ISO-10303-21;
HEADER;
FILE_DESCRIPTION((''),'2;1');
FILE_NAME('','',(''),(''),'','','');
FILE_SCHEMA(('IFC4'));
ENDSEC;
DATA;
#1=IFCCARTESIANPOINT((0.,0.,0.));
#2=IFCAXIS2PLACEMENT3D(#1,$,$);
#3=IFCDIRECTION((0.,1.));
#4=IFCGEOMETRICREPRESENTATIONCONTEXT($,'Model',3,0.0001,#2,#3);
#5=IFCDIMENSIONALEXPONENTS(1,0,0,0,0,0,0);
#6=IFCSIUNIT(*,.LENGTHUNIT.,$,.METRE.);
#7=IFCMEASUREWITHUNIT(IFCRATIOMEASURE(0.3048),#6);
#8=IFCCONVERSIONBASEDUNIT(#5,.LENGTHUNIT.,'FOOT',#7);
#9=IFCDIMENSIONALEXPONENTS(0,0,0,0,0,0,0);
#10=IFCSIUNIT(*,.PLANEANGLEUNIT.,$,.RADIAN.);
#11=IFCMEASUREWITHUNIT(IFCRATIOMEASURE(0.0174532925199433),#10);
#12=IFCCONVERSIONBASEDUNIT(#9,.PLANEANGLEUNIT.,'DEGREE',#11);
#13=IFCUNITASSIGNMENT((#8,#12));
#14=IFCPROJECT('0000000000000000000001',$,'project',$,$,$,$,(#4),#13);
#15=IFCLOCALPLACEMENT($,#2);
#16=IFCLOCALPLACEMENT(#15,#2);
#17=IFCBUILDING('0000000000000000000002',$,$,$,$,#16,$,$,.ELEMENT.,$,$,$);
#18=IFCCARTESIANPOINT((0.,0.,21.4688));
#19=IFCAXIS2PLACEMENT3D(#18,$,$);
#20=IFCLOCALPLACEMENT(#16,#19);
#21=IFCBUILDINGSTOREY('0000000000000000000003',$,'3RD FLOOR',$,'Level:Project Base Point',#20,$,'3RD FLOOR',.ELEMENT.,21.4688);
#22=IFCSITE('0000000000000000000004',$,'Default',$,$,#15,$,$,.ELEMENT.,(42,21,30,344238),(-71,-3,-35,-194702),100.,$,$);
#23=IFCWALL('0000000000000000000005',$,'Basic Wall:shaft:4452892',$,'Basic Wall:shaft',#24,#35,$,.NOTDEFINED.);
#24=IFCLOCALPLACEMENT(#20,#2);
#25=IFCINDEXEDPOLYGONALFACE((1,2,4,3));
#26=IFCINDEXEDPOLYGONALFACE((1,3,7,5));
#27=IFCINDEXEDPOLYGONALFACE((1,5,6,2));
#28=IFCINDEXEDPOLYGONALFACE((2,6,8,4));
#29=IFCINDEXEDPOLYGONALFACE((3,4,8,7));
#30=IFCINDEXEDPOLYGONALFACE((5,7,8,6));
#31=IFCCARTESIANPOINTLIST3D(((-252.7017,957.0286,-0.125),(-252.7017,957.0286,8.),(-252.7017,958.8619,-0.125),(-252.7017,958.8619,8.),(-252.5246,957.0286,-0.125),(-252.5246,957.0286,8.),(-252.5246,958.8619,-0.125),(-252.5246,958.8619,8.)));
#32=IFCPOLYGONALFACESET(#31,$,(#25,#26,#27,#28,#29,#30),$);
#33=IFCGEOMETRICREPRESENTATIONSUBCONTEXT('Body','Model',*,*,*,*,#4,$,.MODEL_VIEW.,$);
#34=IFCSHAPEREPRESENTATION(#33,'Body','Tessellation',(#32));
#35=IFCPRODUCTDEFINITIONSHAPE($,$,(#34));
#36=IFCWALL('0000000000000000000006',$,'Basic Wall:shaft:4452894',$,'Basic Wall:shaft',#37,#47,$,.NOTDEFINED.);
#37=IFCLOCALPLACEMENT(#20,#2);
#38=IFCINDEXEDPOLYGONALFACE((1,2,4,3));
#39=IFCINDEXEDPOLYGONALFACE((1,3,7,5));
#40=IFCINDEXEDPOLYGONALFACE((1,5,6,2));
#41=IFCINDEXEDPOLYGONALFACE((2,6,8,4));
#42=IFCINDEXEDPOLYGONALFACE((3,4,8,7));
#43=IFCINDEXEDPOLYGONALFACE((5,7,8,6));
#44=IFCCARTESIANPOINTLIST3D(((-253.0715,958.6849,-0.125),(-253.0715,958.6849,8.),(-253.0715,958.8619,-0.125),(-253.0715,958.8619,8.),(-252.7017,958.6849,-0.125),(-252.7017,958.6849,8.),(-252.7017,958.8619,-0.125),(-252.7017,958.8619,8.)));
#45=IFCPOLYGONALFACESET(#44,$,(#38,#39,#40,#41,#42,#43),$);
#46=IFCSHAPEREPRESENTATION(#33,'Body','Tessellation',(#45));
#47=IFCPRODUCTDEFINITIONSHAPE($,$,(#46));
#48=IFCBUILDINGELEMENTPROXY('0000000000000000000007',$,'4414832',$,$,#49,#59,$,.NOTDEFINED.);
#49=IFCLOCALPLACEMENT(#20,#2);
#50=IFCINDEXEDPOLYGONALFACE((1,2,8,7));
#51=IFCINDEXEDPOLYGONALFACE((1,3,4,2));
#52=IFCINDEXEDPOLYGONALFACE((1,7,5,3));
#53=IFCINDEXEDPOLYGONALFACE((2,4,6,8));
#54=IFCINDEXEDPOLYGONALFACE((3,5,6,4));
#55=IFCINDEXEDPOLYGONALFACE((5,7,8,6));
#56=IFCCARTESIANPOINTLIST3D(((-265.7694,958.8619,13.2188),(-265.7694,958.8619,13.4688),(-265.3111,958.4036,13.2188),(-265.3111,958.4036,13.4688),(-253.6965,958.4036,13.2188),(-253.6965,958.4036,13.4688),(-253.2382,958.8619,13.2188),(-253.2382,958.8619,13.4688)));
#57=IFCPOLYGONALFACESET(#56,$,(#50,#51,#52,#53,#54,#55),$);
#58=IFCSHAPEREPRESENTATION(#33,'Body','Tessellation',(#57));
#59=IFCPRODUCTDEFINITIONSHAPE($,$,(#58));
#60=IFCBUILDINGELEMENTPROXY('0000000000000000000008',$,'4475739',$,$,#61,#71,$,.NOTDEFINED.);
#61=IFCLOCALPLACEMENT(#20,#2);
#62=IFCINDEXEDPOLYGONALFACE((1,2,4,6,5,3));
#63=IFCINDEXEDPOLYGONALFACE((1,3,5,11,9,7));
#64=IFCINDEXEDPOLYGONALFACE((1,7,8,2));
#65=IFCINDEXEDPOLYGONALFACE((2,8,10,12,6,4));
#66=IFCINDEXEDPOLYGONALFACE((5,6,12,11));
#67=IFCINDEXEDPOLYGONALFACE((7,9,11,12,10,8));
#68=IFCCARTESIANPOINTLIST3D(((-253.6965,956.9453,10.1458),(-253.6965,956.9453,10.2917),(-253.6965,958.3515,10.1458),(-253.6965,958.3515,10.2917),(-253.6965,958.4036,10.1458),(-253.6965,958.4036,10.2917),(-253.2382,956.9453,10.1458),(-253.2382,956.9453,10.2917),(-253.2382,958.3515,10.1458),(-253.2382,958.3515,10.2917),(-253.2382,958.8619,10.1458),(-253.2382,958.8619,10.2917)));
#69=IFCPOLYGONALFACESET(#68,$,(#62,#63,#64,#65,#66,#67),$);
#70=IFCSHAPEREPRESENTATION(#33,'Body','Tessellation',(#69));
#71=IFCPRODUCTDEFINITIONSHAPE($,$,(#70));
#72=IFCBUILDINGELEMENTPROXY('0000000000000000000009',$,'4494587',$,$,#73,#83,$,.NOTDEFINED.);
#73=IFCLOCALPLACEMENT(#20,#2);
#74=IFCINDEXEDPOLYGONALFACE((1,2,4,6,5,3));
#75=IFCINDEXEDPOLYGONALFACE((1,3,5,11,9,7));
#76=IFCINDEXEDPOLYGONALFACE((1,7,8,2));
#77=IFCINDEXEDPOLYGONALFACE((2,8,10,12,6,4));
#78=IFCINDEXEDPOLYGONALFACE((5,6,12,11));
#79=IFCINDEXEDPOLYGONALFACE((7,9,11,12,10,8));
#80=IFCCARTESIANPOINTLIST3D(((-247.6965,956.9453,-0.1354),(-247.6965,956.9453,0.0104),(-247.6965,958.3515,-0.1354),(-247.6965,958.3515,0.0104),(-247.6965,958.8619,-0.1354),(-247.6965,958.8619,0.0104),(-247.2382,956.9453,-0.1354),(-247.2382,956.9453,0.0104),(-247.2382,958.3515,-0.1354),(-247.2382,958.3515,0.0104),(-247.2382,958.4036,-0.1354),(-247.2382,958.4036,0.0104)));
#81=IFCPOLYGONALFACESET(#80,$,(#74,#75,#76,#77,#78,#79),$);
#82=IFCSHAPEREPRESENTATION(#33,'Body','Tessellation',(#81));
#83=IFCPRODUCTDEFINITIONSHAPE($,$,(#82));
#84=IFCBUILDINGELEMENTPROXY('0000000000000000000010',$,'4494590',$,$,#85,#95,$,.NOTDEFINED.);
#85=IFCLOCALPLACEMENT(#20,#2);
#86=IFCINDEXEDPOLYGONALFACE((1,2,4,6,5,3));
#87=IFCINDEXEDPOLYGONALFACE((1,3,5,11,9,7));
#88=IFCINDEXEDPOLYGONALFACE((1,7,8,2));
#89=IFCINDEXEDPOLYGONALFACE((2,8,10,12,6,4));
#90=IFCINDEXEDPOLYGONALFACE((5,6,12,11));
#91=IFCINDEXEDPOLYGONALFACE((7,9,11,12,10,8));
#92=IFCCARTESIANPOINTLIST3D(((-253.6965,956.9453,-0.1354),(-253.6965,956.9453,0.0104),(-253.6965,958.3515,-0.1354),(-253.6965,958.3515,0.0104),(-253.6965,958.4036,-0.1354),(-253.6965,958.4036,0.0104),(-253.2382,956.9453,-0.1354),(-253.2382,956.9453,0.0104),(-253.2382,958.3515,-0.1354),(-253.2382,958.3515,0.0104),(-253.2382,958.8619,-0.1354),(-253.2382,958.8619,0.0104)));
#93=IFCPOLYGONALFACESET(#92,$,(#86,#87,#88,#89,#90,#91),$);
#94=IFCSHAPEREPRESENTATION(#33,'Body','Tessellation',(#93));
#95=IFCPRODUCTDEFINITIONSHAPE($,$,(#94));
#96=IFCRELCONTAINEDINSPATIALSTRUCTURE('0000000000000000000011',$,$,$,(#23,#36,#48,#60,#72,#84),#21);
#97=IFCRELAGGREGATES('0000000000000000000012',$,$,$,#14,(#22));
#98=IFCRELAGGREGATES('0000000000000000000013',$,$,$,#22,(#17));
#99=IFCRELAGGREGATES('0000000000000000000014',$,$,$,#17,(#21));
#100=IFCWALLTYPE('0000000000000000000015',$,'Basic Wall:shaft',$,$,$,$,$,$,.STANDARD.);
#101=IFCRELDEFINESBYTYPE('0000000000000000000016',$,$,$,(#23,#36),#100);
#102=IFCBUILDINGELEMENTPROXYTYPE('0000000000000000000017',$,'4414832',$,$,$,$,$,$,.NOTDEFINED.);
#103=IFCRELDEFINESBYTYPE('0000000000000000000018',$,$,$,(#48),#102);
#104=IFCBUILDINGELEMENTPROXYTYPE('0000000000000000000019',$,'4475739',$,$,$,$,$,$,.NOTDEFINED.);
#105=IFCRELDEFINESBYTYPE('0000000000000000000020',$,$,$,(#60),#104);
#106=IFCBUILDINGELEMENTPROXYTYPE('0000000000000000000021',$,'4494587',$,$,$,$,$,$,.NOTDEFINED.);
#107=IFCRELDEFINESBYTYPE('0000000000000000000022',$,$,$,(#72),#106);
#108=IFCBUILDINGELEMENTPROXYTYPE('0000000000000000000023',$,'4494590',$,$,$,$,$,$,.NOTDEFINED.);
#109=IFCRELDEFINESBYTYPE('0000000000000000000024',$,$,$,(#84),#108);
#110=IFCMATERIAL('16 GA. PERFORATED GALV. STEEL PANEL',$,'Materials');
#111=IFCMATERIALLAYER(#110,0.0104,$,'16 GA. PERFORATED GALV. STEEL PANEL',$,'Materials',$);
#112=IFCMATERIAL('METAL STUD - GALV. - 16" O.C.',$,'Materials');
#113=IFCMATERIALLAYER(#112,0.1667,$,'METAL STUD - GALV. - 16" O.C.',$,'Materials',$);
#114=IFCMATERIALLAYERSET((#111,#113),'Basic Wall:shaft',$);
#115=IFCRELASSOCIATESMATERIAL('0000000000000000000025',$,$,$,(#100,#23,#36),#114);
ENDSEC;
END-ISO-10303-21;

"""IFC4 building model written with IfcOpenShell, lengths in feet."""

from ifc_helpers import new_model, entity, si_unit, converted_unit, direction, frame, frame_2d, origin, place, context, subcontext, project, spatial, polyline, rectangle, outline, extrude, material, layer, layer_set, layer_usage, type_object, element, save


model = new_model("IFC4")

# Units and contexts
model_context = context("Model", 3, precision=0.0001, world=origin(), true_north=direction((0.0, 1.0)))
body_context = subcontext(model_context, "Body", "Model", "MODEL_VIEW")
ifc_project = project(units=[converted_unit("LENGTHUNIT", "FOOT", entity("IfcRatioMeasure", 0.3048), si_unit("LENGTHUNIT", "METRE"), dimensions=[1, 0, 0, 0, 0, 0, 0]), converted_unit("PLANEANGLEUNIT", "DEGREE", entity("IfcRatioMeasure", 0.0174532925199433), si_unit("PLANEANGLEUNIT", "RADIAN"), dimensions=[0, 0, 0, 0, 0, 0, 0])], contexts=[model_context])

# Site, building, storey
site_placement = place(None, origin())
site = spatial("IfcSite", under=ifc_project, at=site_placement, Name="Default", CompositionType="ELEMENT", RefLatitude=(42, 21, 30, 344238), RefLongitude=(-71, -3, -35, -194702), RefElevation=100.0)
building_placement = place(site_placement, origin())
building = spatial("IfcBuilding", under=site, at=building_placement, CompositionType="ELEMENT")
storey_placement = place(building_placement, frame((0.0, 0.0, 21.4688)))
storey = spatial("IfcBuildingStorey", under=building, at=storey_placement, Name="3RD FLOOR", ObjectType="Level:Project Base Point", LongName="3RD FLOOR", CompositionType="ELEMENT", Elevation=21.4688)

# Walls
ifc_material_1 = material(Name="16 GA. PERFORATED GALV. STEEL PANEL", Category="Materials")
ifc_layer_1 = layer(ifc_material_1, 0.0104, Name="16 GA. PERFORATED GALV. STEEL PANEL", Category="Materials")
ifc_material_2 = material(Name="METAL STUD - GALV. - 16\" O.C.", Category="Materials")
ifc_layer_2 = layer(ifc_material_2, 0.1667, Name="METAL STUD - GALV. - 16\" O.C.", Category="Materials")
ifc_layer_set_1 = layer_set([ifc_layer_1, ifc_layer_2], Name="Basic Wall:shaft")
ifc_layer_usage_1 = layer_usage(ifc_layer_set_1, "AXIS2", "POSITIVE", -0.0885)
wall_type_1 = type_object("IfcWallType", Name="Basic Wall:shaft", PredefinedType="STANDARD", material=ifc_layer_set_1)
wall_1_placement = place(storey_placement, frame((-252.6132, 957.0286, -0.125), z_axis=(0.0, 0.0, 1.0), x_axis=(0.0, 1.0, 0.0)))
element("IfcWall", 1, at=wall_1_placement, inside=storey, type_object=wall_type_1, material=ifc_layer_usage_1, Name="Basic Wall:shaft:4452892", ObjectType="Basic Wall:shaft", PredefinedType="NOTDEFINED", context=body_context, shape_type="SweptSolid", body=[
    extrude(rectangle(XDim=1.8333, YDim=0.1771, at=frame_2d((0.9167, 0.0), x_axis=(-1.0, 0.0))), origin(), (0.0, 0.0, 1.0), 8.125),
])
ifc_layer_usage_2 = layer_usage(ifc_layer_set_1, "AXIS2", "NEGATIVE", 0.0885)
wall_2_placement = place(storey_placement, frame((-253.0715, 958.7734, -0.125)))
element("IfcWall", 2, at=wall_2_placement, inside=storey, type_object=wall_type_1, material=ifc_layer_usage_2, Name="Basic Wall:shaft:4452894", ObjectType="Basic Wall:shaft", PredefinedType="NOTDEFINED", context=body_context, shape_type="SweptSolid", body=[
    extrude(rectangle(XDim=0.3698, YDim=0.1771, at=frame_2d((0.1849, 0.0), x_axis=(-1.0, 0.0))), origin(), (0.0, 0.0, 1.0), 8.125),
])

# Building element proxies
building_element_proxy_type_1 = type_object("IfcBuildingElementProxyType", Name="4414832", PredefinedType="NOTDEFINED")
proxy_1_placement = place(storey_placement, frame((-265.7694, 958.4036, 13.2188)))
element("IfcBuildingElementProxy", 3, at=proxy_1_placement, inside=storey, type_object=building_element_proxy_type_1, Name="4414832", PredefinedType="NOTDEFINED", context=body_context, shape_type="SweptSolid", body=[
    extrude(outline(polyline([(-5.8073, -0.2292), (5.8073, -0.2292), (6.2656, 0.2292), (-6.2656, 0.2292), (-5.8073, -0.2292)])), frame((6.2656, 0.2292, 0.0)), (0.0, 0.0, 1.0), 0.25),
])
building_element_proxy_type_2 = type_object("IfcBuildingElementProxyType", Name="4475739", PredefinedType="NOTDEFINED")
proxy_2_placement = place(storey_placement, frame((-253.6965, 956.9453, 10.1458)))
element("IfcBuildingElementProxy", 4, at=proxy_2_placement, inside=storey, type_object=building_element_proxy_type_2, Name="4475739", PredefinedType="NOTDEFINED", context=body_context, shape_type="SweptSolid", body=[
    extrude(outline(polyline([(-1.0312, -0.2292), (0.375, -0.2292), (0.8854, -0.2292), (0.4271, 0.2292), (0.375, 0.2292), (-1.0312, 0.2292), (-1.0312, -0.2292)])), frame((0.2292, 1.0312, 0.0), z_axis=(0.0, 0.0, 1.0), x_axis=(0.0, 1.0, 0.0)), (0.0, 0.0, 1.0), 0.1458),
])
building_element_proxy_type_3 = type_object("IfcBuildingElementProxyType", Name="4494587", PredefinedType="NOTDEFINED")
proxy_3_placement = place(storey_placement, frame((-247.6965, 956.9453, -0.1354)))
element("IfcBuildingElementProxy", 5, at=proxy_3_placement, inside=storey, type_object=building_element_proxy_type_3, Name="4494587", PredefinedType="NOTDEFINED", context=body_context, shape_type="SweptSolid", body=[
    extrude(outline(polyline([(-1.0313, -0.2292), (0.375, -0.2292), (0.4271, -0.2292), (0.8854, 0.2292), (0.375, 0.2292), (-1.0313, 0.2292), (-1.0313, -0.2292)])), frame((0.2292, 1.0313, 0.0), z_axis=(0.0, 0.0, 1.0), x_axis=(0.0, 1.0, 0.0)), (0.0, 0.0, 1.0), 0.1458),
])
building_element_proxy_type_4 = type_object("IfcBuildingElementProxyType", Name="4494590", PredefinedType="NOTDEFINED")
proxy_4_placement = place(storey_placement, frame((-253.6965, 956.9453, -0.1354)))
element("IfcBuildingElementProxy", 6, at=proxy_4_placement, inside=storey, type_object=building_element_proxy_type_4, Name="4494590", PredefinedType="NOTDEFINED", context=body_context, shape_type="SweptSolid", body=[
    extrude(outline(polyline([(-1.0312, -0.2292), (0.375, -0.2292), (0.8854, -0.2292), (0.4271, 0.2292), (0.375, 0.2292), (-1.0312, 0.2292), (-1.0312, -0.2292)])), frame((0.2292, 1.0312, 0.0), z_axis=(0.0, 0.0, 1.0), x_axis=(0.0, 1.0, 0.0)), (0.0, 0.0, 1.0), 0.1458),
])

save(model, "model.ifc")
